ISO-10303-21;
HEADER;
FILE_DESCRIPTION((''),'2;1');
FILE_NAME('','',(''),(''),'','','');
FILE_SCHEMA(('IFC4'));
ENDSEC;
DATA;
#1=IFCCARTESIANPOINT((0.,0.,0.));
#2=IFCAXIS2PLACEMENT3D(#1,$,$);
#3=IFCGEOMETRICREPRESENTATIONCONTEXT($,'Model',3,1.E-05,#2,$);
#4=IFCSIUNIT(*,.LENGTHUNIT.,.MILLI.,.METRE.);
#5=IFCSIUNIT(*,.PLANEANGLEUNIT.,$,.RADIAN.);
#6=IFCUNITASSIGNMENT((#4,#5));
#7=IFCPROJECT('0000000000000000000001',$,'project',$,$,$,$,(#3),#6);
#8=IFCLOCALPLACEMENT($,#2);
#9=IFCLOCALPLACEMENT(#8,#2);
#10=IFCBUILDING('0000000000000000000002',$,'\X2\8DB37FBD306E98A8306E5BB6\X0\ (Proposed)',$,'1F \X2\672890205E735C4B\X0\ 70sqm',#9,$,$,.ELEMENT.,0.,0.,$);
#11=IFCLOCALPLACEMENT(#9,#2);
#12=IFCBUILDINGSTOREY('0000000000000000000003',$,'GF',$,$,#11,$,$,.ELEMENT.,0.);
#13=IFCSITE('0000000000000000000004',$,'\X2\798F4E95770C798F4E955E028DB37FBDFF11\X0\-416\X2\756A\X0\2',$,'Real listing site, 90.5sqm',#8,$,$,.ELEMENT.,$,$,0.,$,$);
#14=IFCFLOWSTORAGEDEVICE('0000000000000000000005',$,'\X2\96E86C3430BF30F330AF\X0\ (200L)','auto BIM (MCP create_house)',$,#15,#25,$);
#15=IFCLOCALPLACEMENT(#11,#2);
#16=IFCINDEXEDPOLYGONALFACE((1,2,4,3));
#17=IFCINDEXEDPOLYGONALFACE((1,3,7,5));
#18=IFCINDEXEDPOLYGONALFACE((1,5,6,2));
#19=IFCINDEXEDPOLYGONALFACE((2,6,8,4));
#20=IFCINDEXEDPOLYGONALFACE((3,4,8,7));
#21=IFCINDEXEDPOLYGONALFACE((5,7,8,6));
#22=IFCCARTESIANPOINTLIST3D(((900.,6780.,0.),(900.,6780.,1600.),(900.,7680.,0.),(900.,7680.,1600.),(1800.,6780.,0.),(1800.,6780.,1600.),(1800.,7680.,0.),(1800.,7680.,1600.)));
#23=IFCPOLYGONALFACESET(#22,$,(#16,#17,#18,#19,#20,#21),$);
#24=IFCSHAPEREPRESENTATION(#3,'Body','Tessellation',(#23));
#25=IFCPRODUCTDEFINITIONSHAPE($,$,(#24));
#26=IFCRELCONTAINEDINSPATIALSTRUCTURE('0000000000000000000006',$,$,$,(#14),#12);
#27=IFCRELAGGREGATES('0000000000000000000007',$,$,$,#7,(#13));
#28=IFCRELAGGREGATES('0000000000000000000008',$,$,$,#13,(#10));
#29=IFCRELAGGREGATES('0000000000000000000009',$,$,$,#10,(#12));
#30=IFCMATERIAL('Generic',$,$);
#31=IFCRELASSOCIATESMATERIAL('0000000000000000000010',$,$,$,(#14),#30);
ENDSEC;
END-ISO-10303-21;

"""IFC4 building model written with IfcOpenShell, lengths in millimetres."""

from ifc_helpers import new_model, si_unit, frame, frame_2d, origin, place, context, project, spatial, rectangle, extrude, material, element, save


model = new_model("IFC4")

# Units and contexts
model_context = context("Model", 3, precision=1e-05, world=origin())
ifc_project = project(units=[si_unit("LENGTHUNIT", "METRE", prefix="MILLI"), si_unit("PLANEANGLEUNIT", "RADIAN")], contexts=[model_context])

# Site, building, storey
site_placement = place(None, origin())
site = spatial("IfcSite", under=ifc_project, at=site_placement, Name="福井県福井市足羽１-416番2", ObjectType="Real listing site, 90.5sqm", CompositionType="ELEMENT", RefElevation=0.0)
building_placement = place(site_placement, origin())
building = spatial("IfcBuilding", under=site, at=building_placement, Name="足羽の風の家 (Proposed)", ObjectType="1F 木造平屋 70sqm", CompositionType="ELEMENT", ElevationOfRefHeight=0.0, ElevationOfTerrain=0.0)
storey_placement = place(building_placement, origin())
storey = spatial("IfcBuildingStorey", under=building, at=storey_placement, Name="GF", CompositionType="ELEMENT", Elevation=0.0)

# Shared definitions
ifc_material_1 = material(Name="Generic")

# Flow storage device
flow_storage_device_placement = place(storey_placement, frame((450.0, 3390.0, 0.0)))
element("IfcFlowStorageDevice", 1, at=flow_storage_device_placement, inside=storey, material=ifc_material_1, Name="雨水タンク (200L)", Description="auto BIM (MCP create_house)", context=model_context, shape_type="SweptSolid", body=[
    extrude(rectangle(XDim=900.0, YDim=900.0, at=frame_2d((450.0, 450.0))), frame((450.0, 3390.0, 0.0)), (0.0, 0.0, 1.0), 1600.0),
])

save(model, "model.ifc")
